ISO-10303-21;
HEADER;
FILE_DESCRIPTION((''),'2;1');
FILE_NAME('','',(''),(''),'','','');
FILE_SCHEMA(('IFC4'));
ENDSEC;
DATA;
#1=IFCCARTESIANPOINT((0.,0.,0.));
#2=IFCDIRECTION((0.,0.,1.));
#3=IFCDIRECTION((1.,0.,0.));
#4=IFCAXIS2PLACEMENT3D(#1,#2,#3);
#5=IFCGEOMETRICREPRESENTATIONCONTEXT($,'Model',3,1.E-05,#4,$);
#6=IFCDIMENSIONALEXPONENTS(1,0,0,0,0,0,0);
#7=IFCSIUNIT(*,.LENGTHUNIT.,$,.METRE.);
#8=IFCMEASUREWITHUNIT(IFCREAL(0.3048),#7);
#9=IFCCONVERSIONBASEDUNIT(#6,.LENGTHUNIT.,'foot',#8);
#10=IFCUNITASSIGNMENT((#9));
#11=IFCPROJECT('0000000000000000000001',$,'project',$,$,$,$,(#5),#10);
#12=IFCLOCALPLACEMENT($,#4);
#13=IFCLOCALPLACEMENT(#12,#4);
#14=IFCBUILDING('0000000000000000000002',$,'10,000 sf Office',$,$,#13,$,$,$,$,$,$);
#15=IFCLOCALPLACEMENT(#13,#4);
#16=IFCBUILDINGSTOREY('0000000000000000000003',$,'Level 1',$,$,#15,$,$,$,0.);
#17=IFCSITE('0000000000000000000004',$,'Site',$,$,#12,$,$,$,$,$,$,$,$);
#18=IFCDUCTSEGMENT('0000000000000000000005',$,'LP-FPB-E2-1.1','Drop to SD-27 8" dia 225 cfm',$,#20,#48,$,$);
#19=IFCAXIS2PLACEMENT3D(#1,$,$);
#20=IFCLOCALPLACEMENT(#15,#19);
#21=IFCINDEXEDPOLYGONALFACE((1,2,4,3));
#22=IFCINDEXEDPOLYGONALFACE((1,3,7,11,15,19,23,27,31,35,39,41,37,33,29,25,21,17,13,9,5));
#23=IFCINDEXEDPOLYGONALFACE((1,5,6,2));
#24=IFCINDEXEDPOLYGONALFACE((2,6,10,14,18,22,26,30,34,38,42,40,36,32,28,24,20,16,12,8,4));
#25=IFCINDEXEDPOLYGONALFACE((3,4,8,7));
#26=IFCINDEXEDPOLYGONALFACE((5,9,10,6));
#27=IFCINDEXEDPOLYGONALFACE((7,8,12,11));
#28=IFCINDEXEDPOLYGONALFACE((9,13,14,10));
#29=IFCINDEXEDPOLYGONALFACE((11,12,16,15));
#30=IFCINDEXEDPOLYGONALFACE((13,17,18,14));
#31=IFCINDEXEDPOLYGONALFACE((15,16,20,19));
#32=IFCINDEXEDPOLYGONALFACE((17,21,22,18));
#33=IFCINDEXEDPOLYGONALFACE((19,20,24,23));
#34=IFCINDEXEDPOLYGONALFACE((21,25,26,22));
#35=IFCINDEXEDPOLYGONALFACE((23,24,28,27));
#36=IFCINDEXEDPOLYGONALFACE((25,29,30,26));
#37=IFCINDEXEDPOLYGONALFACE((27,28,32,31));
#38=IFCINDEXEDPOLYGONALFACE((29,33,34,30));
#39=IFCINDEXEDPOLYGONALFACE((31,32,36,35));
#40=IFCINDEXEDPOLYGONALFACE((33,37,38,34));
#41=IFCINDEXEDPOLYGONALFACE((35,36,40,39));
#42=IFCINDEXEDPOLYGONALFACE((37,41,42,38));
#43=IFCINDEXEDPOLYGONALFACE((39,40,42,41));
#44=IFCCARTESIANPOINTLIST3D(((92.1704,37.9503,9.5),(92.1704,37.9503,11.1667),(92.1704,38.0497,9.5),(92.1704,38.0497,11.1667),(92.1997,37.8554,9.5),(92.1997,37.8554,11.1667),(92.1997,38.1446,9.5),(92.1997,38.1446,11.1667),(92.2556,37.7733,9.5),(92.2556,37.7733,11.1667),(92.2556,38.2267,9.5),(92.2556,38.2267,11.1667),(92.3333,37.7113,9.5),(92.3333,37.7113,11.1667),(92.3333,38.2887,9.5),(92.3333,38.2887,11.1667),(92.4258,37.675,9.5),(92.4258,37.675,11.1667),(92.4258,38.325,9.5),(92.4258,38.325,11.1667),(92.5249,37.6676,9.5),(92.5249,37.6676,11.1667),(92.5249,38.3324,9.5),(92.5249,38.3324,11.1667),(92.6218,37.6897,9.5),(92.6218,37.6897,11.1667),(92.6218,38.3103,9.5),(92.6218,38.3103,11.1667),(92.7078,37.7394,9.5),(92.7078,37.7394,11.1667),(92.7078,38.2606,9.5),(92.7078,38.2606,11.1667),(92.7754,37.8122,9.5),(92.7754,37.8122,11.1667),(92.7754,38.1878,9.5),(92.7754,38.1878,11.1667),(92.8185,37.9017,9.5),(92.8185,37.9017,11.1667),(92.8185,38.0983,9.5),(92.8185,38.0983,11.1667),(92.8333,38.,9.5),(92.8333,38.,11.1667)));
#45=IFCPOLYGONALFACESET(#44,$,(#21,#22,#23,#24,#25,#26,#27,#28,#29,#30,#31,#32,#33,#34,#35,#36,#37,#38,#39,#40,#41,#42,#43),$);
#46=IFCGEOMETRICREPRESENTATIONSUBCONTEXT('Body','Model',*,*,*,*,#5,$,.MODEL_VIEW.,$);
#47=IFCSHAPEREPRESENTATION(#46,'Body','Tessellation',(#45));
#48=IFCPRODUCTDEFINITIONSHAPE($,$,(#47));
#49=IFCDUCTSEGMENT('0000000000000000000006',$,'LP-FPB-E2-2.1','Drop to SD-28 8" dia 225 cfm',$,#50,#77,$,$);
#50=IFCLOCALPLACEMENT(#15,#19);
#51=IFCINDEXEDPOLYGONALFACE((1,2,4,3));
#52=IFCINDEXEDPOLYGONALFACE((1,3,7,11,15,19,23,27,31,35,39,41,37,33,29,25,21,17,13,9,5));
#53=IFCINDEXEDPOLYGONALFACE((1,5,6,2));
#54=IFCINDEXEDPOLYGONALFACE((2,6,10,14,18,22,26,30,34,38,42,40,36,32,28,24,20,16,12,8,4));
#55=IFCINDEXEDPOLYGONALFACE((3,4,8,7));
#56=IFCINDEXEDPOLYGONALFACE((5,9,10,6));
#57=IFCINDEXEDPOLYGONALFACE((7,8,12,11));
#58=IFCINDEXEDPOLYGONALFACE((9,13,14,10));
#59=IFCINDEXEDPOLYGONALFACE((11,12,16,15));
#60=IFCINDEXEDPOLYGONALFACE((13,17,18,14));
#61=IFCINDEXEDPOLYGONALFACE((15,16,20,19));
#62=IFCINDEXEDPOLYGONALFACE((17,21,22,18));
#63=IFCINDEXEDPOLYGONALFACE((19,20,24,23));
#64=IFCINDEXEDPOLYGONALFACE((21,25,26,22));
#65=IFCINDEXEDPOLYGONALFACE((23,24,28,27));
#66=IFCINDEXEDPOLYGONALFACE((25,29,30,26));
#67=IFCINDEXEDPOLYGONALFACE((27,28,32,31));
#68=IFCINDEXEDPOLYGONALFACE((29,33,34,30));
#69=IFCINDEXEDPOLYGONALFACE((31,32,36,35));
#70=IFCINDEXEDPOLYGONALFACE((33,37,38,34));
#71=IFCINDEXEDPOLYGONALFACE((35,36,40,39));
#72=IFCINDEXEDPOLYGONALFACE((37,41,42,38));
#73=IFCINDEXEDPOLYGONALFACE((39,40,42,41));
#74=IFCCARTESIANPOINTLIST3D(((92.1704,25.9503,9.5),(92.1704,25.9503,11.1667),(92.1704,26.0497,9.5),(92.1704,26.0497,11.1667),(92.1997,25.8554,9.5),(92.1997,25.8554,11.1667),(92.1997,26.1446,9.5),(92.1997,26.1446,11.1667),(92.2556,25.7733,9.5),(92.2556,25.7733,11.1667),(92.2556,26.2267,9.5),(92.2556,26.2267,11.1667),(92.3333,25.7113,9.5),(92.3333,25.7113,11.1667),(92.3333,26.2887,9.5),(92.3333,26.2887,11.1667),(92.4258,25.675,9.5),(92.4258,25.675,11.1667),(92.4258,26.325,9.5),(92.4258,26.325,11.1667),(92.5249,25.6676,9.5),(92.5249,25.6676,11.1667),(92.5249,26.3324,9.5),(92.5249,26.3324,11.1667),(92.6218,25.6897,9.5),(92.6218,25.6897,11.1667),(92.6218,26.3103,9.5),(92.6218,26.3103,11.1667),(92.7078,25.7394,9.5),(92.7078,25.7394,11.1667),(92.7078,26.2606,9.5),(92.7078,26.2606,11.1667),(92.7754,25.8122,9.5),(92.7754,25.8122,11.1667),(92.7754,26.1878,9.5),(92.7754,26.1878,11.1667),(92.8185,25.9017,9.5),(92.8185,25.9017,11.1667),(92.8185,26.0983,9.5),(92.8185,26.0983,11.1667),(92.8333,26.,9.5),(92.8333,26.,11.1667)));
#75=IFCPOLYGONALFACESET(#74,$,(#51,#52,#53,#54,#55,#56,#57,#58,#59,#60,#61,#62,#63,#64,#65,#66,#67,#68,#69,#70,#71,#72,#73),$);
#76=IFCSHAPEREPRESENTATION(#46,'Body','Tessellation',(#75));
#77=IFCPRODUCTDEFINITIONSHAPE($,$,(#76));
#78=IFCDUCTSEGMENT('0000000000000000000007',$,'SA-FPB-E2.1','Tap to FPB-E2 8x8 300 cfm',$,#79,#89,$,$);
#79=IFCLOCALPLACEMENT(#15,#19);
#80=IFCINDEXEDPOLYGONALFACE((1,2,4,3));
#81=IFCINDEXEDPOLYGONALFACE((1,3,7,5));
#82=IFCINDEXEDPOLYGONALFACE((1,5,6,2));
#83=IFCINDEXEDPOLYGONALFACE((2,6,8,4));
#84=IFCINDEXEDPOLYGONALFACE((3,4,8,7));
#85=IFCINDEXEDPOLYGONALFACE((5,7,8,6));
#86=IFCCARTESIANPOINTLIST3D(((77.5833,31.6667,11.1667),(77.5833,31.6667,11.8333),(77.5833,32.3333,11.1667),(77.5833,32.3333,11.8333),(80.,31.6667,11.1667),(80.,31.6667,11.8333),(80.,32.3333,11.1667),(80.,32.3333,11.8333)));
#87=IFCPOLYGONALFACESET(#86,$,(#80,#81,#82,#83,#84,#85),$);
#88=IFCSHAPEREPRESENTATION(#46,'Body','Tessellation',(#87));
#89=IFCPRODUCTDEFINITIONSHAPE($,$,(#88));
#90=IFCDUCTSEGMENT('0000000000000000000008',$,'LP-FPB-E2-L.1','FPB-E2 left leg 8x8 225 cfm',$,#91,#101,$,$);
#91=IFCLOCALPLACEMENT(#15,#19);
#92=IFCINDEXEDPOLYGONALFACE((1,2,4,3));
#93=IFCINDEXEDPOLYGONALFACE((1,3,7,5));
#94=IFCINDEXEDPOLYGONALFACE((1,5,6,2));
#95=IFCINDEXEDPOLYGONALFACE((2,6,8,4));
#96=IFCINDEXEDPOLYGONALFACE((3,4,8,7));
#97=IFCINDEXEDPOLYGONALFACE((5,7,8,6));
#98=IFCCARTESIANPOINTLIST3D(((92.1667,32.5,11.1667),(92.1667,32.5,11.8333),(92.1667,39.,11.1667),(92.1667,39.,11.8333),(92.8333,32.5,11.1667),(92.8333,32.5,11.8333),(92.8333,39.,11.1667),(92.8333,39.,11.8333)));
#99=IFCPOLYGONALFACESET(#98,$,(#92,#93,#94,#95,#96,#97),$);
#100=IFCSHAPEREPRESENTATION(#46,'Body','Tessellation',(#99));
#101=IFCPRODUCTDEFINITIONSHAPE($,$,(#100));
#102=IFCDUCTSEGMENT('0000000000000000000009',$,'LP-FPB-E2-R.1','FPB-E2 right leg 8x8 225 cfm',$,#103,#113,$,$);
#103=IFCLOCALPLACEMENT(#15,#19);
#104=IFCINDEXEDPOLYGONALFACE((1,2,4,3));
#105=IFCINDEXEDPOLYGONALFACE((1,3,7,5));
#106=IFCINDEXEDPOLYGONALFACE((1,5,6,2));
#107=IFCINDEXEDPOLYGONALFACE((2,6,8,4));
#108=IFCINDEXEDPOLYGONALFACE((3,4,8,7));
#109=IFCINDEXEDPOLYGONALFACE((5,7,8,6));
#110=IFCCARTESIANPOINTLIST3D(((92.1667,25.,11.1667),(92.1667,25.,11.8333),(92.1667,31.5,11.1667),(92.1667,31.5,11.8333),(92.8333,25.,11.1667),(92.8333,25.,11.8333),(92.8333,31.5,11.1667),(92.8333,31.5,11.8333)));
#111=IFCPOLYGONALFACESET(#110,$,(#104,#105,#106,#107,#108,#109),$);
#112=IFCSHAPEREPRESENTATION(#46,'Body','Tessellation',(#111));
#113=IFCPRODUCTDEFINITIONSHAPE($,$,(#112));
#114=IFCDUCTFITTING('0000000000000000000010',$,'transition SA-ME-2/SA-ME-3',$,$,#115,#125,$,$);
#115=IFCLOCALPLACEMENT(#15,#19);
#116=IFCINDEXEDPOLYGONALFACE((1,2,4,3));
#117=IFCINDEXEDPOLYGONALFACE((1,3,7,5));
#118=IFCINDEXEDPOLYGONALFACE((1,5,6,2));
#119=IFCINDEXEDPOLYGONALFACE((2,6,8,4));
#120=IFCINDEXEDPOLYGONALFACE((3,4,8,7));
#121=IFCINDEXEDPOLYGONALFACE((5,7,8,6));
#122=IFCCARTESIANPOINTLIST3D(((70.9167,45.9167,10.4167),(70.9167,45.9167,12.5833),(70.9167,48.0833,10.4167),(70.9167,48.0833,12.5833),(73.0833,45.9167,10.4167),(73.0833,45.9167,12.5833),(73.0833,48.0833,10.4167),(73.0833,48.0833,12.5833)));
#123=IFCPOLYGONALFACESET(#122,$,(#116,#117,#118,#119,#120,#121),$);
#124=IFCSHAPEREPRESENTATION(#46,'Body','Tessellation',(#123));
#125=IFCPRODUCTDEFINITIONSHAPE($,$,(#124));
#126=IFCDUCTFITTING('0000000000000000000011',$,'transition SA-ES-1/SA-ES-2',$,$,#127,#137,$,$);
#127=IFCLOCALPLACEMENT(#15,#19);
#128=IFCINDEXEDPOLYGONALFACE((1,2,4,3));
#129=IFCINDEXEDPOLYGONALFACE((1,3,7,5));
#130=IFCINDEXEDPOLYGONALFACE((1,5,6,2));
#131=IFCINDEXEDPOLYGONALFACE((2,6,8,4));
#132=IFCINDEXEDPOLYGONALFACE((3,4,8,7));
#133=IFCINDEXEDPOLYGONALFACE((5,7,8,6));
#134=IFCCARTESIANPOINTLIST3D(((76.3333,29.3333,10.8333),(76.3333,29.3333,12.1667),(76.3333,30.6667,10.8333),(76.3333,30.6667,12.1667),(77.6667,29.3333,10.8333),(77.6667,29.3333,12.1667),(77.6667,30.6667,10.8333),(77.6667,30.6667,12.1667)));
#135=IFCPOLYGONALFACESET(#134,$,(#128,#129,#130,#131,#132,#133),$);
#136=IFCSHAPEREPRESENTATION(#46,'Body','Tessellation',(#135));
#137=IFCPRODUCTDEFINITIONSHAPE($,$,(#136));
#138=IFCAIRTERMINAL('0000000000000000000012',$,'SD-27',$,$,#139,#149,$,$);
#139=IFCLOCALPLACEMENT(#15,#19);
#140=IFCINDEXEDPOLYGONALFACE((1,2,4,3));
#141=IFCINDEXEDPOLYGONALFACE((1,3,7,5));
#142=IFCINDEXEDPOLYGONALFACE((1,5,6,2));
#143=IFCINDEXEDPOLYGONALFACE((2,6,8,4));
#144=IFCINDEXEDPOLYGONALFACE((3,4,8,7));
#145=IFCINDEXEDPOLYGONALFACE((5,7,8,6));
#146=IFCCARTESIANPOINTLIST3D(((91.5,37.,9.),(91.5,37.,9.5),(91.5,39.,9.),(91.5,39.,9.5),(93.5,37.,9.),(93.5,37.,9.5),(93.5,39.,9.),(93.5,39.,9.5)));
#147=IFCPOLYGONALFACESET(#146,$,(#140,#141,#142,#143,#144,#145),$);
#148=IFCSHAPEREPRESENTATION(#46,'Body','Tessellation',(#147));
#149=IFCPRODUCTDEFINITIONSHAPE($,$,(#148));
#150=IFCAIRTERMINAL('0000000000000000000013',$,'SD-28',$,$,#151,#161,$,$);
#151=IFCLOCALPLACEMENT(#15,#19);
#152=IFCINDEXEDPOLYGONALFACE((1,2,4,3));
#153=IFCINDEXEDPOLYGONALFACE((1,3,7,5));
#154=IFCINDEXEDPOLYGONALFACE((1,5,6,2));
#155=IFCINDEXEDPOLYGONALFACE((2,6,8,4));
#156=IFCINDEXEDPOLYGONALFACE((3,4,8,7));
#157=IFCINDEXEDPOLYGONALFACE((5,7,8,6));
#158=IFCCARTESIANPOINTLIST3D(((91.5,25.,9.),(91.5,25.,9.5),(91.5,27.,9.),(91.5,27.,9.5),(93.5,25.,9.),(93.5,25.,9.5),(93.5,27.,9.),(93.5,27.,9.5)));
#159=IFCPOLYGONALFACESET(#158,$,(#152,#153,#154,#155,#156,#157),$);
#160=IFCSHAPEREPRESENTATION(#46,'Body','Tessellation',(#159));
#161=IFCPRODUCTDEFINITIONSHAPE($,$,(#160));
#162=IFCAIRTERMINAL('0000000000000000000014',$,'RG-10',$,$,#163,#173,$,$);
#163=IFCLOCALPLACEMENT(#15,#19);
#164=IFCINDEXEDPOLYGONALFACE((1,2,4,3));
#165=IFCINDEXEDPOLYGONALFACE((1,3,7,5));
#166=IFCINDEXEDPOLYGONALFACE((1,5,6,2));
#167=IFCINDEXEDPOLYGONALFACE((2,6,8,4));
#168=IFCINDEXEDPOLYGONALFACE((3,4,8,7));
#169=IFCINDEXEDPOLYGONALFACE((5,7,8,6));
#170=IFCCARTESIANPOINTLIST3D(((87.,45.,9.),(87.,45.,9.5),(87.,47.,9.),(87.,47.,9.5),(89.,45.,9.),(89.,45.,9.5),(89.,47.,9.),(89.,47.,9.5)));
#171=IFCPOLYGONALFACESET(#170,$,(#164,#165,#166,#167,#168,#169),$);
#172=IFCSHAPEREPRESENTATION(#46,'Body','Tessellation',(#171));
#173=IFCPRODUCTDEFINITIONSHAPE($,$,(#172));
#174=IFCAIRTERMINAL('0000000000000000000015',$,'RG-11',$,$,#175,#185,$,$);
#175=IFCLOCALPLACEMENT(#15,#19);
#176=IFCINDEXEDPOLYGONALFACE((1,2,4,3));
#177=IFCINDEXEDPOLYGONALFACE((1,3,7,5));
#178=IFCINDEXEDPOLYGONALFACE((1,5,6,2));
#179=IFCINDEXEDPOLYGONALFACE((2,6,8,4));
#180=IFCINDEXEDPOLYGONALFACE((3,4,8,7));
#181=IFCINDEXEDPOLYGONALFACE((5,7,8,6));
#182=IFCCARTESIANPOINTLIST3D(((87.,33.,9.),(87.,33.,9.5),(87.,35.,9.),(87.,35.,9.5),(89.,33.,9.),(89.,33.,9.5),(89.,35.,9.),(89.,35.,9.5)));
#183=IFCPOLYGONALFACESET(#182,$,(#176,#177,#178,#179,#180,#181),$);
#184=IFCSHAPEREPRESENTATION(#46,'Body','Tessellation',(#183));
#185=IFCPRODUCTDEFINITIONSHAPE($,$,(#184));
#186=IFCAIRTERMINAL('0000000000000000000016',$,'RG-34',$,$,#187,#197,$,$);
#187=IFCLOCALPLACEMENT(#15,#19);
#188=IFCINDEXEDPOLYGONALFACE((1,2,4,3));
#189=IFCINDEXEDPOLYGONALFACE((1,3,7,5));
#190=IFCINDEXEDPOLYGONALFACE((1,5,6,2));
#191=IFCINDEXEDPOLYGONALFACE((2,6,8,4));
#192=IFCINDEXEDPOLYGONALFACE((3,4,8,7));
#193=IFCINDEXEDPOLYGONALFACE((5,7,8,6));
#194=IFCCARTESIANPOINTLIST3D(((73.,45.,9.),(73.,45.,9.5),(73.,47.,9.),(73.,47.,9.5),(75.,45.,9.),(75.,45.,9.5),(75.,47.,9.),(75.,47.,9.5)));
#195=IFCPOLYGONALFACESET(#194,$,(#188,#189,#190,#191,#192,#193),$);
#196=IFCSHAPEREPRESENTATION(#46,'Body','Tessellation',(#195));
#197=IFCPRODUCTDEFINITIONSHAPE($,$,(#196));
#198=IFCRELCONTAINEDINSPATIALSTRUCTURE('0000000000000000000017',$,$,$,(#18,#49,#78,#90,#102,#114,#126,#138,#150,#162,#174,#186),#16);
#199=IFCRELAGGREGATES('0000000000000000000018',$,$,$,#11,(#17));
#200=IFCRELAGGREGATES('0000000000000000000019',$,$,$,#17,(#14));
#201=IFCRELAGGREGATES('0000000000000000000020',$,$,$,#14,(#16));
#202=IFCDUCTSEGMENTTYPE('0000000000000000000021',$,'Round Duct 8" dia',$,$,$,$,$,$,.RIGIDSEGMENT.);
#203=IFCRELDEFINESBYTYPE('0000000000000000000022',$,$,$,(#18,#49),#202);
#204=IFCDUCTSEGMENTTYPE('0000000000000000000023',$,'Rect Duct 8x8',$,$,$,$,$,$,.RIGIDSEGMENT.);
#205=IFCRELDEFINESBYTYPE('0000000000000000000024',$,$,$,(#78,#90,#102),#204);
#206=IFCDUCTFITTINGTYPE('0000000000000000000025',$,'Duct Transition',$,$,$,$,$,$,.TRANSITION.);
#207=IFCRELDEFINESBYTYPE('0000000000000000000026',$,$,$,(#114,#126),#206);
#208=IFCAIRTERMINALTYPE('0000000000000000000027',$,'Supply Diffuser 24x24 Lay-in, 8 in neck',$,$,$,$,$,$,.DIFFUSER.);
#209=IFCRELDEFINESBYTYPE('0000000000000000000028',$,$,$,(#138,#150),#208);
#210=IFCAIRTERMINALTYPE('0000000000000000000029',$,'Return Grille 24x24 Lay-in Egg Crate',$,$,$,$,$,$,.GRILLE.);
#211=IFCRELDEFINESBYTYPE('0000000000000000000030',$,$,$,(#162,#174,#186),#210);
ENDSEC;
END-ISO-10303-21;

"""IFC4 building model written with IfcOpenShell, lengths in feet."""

from ifc_helpers import new_model, entity, si_unit, converted_unit, frame, origin_with_axes, place, context, subcontext, project, spatial, rectangle, circle, extrude, type_object, element, save


model = new_model("IFC4")

# Units and contexts
model_context = context("Model", 3, precision=1e-05, world=origin_with_axes())
body_context = subcontext(model_context, "Body", "Model", "MODEL_VIEW")
ifc_project = project(units=[converted_unit("LENGTHUNIT", "foot", entity("IfcReal", 0.3048), si_unit("LENGTHUNIT", "METRE"), dimensions=[1, 0, 0, 0, 0, 0, 0])], contexts=[model_context])

# Site, building, storey
site_placement = place(None, origin_with_axes())
site = spatial("IfcSite", under=ifc_project, at=site_placement, Name="Site")
building_placement = place(site_placement, origin_with_axes())
building = spatial("IfcBuilding", under=site, at=building_placement, Name="10,000 sf Office")
storey_placement = place(building_placement, origin_with_axes())
storey = spatial("IfcBuildingStorey", under=building, at=storey_placement, Name="Level 1", Elevation=0.0)

# Duct segments
duct_segment_type_1 = type_object("IfcDuctSegmentType", Name="Round Duct 8\" dia", PredefinedType="RIGIDSEGMENT")
for number, where, z_axis, x_axis, name, description in (
    (1, (92.5, 38.0, 11.1667), (0.0, 0.0, -1.0), (1.0, 0.0, 0.0), "LP-FPB-E2-1.1", "Drop to SD-27 8\" dia 225 cfm"),
    (2, (92.5, 26.0, 11.1667), (0.0, 0.0, -1.0), (1.0, 0.0, 0.0), "LP-FPB-E2-2.1", "Drop to SD-28 8\" dia 225 cfm"),
):
    element("IfcDuctSegment", number, at=place(storey_placement, frame(where, z_axis=z_axis, x_axis=x_axis)), inside=storey, type_object=duct_segment_type_1, Name=name, Description=description, context=body_context, shape_type="SweptSolid", body=[
        extrude(circle(Radius=0.3333), None, (0.0, 0.0, 1.0), 1.6667),
    ])
duct_segment_type_2 = type_object("IfcDuctSegmentType", Name="Rect Duct 8x8", PredefinedType="RIGIDSEGMENT")
duct_segment_1_placement = place(storey_placement, frame((77.5833, 32.0, 11.5), z_axis=(1.0, 0.0, 0.0), x_axis=(0.0, 1.0, 0.0)))
element("IfcDuctSegment", 3, at=duct_segment_1_placement, inside=storey, type_object=duct_segment_type_2, Name="SA-FPB-E2.1", Description="Tap to FPB-E2 8x8 300 cfm", context=body_context, shape_type="SweptSolid", body=[
    extrude(rectangle(XDim=0.6667, YDim=0.6667), None, (0.0, 0.0, 1.0), 2.4167),
])
for number, where, z_axis, x_axis, name, description in (
    (4, (92.5, 32.5, 11.5), (0.0, 1.0, 0.0), (-1.0, 0.0, 0.0), "LP-FPB-E2-L.1", "FPB-E2 left leg 8x8 225 cfm"),
    (5, (92.5, 31.5, 11.5), (0.0, -1.0, 0.0), (1.0, 0.0, 0.0), "LP-FPB-E2-R.1", "FPB-E2 right leg 8x8 225 cfm"),
):
    element("IfcDuctSegment", number, at=place(storey_placement, frame(where, z_axis=z_axis, x_axis=x_axis)), inside=storey, type_object=duct_segment_type_2, Name=name, Description=description, context=body_context, shape_type="SweptSolid", body=[
        extrude(rectangle(XDim=0.6667, YDim=0.6667), None, (0.0, 0.0, 1.0), 6.5),
    ])

# Duct fittings
duct_fitting_type_1 = type_object("IfcDuctFittingType", Name="Duct Transition", PredefinedType="TRANSITION")
duct_fitting_1_placement = place(storey_placement, frame((72.0, 47.0, 10.4167), z_axis=(0.0, 0.0, 1.0), x_axis=(1.0, 0.0, 0.0)))
element("IfcDuctFitting", 6, at=duct_fitting_1_placement, inside=storey, type_object=duct_fitting_type_1, Name="transition SA-ME-2/SA-ME-3", context=body_context, shape_type="SweptSolid", body=[
    extrude(rectangle(XDim=2.1667, YDim=2.1667), None, (0.0, 0.0, 1.0), 2.1667),
])
duct_fitting_2_placement = place(storey_placement, frame((77.0, 30.0, 10.8333), z_axis=(0.0, 0.0, 1.0), x_axis=(1.0, 0.0, 0.0)))
element("IfcDuctFitting", 7, at=duct_fitting_2_placement, inside=storey, type_object=duct_fitting_type_1, Name="transition SA-ES-1/SA-ES-2", context=body_context, shape_type="SweptSolid", body=[
    extrude(rectangle(XDim=1.3333, YDim=1.3333), None, (0.0, 0.0, 1.0), 1.3333),
])

# Air terminals
air_terminal_type_1 = type_object("IfcAirTerminalType", Name="Supply Diffuser 24x24 Lay-in, 8 in neck", PredefinedType="DIFFUSER")
for number, where, z_axis, x_axis, name in (
    (8, (92.5, 38.0, 9.0), (0.0, 0.0, 1.0), (1.0, 0.0, 0.0), "SD-27"),
    (9, (92.5, 26.0, 9.0), (0.0, 0.0, 1.0), (1.0, 0.0, 0.0), "SD-28"),
):
    element("IfcAirTerminal", number, at=place(storey_placement, frame(where, z_axis=z_axis, x_axis=x_axis)), inside=storey, type_object=air_terminal_type_1, Name=name, context=body_context, shape_type="SweptSolid", body=[
        extrude(rectangle(XDim=2.0, YDim=2.0), None, (0.0, 0.0, 1.0), 0.5),
    ])
air_terminal_type_2 = type_object("IfcAirTerminalType", Name="Return Grille 24x24 Lay-in Egg Crate", PredefinedType="GRILLE")
for number, where, z_axis, x_axis, name in (
    (10, (88.0, 46.0, 9.0), (0.0, 0.0, 1.0), (1.0, 0.0, 0.0), "RG-10"),
    (11, (88.0, 34.0, 9.0), (0.0, 0.0, 1.0), (1.0, 0.0, 0.0), "RG-11"),
    (12, (74.0, 46.0, 9.0), (0.0, 0.0, 1.0), (1.0, 0.0, 0.0), "RG-34"),
):
    element("IfcAirTerminal", number, at=place(storey_placement, frame(where, z_axis=z_axis, x_axis=x_axis)), inside=storey, type_object=air_terminal_type_2, Name=name, context=body_context, shape_type="SweptSolid", body=[
        extrude(rectangle(XDim=2.0, YDim=2.0), None, (0.0, 0.0, 1.0), 0.5),
    ])

save(model, "model.ifc")
